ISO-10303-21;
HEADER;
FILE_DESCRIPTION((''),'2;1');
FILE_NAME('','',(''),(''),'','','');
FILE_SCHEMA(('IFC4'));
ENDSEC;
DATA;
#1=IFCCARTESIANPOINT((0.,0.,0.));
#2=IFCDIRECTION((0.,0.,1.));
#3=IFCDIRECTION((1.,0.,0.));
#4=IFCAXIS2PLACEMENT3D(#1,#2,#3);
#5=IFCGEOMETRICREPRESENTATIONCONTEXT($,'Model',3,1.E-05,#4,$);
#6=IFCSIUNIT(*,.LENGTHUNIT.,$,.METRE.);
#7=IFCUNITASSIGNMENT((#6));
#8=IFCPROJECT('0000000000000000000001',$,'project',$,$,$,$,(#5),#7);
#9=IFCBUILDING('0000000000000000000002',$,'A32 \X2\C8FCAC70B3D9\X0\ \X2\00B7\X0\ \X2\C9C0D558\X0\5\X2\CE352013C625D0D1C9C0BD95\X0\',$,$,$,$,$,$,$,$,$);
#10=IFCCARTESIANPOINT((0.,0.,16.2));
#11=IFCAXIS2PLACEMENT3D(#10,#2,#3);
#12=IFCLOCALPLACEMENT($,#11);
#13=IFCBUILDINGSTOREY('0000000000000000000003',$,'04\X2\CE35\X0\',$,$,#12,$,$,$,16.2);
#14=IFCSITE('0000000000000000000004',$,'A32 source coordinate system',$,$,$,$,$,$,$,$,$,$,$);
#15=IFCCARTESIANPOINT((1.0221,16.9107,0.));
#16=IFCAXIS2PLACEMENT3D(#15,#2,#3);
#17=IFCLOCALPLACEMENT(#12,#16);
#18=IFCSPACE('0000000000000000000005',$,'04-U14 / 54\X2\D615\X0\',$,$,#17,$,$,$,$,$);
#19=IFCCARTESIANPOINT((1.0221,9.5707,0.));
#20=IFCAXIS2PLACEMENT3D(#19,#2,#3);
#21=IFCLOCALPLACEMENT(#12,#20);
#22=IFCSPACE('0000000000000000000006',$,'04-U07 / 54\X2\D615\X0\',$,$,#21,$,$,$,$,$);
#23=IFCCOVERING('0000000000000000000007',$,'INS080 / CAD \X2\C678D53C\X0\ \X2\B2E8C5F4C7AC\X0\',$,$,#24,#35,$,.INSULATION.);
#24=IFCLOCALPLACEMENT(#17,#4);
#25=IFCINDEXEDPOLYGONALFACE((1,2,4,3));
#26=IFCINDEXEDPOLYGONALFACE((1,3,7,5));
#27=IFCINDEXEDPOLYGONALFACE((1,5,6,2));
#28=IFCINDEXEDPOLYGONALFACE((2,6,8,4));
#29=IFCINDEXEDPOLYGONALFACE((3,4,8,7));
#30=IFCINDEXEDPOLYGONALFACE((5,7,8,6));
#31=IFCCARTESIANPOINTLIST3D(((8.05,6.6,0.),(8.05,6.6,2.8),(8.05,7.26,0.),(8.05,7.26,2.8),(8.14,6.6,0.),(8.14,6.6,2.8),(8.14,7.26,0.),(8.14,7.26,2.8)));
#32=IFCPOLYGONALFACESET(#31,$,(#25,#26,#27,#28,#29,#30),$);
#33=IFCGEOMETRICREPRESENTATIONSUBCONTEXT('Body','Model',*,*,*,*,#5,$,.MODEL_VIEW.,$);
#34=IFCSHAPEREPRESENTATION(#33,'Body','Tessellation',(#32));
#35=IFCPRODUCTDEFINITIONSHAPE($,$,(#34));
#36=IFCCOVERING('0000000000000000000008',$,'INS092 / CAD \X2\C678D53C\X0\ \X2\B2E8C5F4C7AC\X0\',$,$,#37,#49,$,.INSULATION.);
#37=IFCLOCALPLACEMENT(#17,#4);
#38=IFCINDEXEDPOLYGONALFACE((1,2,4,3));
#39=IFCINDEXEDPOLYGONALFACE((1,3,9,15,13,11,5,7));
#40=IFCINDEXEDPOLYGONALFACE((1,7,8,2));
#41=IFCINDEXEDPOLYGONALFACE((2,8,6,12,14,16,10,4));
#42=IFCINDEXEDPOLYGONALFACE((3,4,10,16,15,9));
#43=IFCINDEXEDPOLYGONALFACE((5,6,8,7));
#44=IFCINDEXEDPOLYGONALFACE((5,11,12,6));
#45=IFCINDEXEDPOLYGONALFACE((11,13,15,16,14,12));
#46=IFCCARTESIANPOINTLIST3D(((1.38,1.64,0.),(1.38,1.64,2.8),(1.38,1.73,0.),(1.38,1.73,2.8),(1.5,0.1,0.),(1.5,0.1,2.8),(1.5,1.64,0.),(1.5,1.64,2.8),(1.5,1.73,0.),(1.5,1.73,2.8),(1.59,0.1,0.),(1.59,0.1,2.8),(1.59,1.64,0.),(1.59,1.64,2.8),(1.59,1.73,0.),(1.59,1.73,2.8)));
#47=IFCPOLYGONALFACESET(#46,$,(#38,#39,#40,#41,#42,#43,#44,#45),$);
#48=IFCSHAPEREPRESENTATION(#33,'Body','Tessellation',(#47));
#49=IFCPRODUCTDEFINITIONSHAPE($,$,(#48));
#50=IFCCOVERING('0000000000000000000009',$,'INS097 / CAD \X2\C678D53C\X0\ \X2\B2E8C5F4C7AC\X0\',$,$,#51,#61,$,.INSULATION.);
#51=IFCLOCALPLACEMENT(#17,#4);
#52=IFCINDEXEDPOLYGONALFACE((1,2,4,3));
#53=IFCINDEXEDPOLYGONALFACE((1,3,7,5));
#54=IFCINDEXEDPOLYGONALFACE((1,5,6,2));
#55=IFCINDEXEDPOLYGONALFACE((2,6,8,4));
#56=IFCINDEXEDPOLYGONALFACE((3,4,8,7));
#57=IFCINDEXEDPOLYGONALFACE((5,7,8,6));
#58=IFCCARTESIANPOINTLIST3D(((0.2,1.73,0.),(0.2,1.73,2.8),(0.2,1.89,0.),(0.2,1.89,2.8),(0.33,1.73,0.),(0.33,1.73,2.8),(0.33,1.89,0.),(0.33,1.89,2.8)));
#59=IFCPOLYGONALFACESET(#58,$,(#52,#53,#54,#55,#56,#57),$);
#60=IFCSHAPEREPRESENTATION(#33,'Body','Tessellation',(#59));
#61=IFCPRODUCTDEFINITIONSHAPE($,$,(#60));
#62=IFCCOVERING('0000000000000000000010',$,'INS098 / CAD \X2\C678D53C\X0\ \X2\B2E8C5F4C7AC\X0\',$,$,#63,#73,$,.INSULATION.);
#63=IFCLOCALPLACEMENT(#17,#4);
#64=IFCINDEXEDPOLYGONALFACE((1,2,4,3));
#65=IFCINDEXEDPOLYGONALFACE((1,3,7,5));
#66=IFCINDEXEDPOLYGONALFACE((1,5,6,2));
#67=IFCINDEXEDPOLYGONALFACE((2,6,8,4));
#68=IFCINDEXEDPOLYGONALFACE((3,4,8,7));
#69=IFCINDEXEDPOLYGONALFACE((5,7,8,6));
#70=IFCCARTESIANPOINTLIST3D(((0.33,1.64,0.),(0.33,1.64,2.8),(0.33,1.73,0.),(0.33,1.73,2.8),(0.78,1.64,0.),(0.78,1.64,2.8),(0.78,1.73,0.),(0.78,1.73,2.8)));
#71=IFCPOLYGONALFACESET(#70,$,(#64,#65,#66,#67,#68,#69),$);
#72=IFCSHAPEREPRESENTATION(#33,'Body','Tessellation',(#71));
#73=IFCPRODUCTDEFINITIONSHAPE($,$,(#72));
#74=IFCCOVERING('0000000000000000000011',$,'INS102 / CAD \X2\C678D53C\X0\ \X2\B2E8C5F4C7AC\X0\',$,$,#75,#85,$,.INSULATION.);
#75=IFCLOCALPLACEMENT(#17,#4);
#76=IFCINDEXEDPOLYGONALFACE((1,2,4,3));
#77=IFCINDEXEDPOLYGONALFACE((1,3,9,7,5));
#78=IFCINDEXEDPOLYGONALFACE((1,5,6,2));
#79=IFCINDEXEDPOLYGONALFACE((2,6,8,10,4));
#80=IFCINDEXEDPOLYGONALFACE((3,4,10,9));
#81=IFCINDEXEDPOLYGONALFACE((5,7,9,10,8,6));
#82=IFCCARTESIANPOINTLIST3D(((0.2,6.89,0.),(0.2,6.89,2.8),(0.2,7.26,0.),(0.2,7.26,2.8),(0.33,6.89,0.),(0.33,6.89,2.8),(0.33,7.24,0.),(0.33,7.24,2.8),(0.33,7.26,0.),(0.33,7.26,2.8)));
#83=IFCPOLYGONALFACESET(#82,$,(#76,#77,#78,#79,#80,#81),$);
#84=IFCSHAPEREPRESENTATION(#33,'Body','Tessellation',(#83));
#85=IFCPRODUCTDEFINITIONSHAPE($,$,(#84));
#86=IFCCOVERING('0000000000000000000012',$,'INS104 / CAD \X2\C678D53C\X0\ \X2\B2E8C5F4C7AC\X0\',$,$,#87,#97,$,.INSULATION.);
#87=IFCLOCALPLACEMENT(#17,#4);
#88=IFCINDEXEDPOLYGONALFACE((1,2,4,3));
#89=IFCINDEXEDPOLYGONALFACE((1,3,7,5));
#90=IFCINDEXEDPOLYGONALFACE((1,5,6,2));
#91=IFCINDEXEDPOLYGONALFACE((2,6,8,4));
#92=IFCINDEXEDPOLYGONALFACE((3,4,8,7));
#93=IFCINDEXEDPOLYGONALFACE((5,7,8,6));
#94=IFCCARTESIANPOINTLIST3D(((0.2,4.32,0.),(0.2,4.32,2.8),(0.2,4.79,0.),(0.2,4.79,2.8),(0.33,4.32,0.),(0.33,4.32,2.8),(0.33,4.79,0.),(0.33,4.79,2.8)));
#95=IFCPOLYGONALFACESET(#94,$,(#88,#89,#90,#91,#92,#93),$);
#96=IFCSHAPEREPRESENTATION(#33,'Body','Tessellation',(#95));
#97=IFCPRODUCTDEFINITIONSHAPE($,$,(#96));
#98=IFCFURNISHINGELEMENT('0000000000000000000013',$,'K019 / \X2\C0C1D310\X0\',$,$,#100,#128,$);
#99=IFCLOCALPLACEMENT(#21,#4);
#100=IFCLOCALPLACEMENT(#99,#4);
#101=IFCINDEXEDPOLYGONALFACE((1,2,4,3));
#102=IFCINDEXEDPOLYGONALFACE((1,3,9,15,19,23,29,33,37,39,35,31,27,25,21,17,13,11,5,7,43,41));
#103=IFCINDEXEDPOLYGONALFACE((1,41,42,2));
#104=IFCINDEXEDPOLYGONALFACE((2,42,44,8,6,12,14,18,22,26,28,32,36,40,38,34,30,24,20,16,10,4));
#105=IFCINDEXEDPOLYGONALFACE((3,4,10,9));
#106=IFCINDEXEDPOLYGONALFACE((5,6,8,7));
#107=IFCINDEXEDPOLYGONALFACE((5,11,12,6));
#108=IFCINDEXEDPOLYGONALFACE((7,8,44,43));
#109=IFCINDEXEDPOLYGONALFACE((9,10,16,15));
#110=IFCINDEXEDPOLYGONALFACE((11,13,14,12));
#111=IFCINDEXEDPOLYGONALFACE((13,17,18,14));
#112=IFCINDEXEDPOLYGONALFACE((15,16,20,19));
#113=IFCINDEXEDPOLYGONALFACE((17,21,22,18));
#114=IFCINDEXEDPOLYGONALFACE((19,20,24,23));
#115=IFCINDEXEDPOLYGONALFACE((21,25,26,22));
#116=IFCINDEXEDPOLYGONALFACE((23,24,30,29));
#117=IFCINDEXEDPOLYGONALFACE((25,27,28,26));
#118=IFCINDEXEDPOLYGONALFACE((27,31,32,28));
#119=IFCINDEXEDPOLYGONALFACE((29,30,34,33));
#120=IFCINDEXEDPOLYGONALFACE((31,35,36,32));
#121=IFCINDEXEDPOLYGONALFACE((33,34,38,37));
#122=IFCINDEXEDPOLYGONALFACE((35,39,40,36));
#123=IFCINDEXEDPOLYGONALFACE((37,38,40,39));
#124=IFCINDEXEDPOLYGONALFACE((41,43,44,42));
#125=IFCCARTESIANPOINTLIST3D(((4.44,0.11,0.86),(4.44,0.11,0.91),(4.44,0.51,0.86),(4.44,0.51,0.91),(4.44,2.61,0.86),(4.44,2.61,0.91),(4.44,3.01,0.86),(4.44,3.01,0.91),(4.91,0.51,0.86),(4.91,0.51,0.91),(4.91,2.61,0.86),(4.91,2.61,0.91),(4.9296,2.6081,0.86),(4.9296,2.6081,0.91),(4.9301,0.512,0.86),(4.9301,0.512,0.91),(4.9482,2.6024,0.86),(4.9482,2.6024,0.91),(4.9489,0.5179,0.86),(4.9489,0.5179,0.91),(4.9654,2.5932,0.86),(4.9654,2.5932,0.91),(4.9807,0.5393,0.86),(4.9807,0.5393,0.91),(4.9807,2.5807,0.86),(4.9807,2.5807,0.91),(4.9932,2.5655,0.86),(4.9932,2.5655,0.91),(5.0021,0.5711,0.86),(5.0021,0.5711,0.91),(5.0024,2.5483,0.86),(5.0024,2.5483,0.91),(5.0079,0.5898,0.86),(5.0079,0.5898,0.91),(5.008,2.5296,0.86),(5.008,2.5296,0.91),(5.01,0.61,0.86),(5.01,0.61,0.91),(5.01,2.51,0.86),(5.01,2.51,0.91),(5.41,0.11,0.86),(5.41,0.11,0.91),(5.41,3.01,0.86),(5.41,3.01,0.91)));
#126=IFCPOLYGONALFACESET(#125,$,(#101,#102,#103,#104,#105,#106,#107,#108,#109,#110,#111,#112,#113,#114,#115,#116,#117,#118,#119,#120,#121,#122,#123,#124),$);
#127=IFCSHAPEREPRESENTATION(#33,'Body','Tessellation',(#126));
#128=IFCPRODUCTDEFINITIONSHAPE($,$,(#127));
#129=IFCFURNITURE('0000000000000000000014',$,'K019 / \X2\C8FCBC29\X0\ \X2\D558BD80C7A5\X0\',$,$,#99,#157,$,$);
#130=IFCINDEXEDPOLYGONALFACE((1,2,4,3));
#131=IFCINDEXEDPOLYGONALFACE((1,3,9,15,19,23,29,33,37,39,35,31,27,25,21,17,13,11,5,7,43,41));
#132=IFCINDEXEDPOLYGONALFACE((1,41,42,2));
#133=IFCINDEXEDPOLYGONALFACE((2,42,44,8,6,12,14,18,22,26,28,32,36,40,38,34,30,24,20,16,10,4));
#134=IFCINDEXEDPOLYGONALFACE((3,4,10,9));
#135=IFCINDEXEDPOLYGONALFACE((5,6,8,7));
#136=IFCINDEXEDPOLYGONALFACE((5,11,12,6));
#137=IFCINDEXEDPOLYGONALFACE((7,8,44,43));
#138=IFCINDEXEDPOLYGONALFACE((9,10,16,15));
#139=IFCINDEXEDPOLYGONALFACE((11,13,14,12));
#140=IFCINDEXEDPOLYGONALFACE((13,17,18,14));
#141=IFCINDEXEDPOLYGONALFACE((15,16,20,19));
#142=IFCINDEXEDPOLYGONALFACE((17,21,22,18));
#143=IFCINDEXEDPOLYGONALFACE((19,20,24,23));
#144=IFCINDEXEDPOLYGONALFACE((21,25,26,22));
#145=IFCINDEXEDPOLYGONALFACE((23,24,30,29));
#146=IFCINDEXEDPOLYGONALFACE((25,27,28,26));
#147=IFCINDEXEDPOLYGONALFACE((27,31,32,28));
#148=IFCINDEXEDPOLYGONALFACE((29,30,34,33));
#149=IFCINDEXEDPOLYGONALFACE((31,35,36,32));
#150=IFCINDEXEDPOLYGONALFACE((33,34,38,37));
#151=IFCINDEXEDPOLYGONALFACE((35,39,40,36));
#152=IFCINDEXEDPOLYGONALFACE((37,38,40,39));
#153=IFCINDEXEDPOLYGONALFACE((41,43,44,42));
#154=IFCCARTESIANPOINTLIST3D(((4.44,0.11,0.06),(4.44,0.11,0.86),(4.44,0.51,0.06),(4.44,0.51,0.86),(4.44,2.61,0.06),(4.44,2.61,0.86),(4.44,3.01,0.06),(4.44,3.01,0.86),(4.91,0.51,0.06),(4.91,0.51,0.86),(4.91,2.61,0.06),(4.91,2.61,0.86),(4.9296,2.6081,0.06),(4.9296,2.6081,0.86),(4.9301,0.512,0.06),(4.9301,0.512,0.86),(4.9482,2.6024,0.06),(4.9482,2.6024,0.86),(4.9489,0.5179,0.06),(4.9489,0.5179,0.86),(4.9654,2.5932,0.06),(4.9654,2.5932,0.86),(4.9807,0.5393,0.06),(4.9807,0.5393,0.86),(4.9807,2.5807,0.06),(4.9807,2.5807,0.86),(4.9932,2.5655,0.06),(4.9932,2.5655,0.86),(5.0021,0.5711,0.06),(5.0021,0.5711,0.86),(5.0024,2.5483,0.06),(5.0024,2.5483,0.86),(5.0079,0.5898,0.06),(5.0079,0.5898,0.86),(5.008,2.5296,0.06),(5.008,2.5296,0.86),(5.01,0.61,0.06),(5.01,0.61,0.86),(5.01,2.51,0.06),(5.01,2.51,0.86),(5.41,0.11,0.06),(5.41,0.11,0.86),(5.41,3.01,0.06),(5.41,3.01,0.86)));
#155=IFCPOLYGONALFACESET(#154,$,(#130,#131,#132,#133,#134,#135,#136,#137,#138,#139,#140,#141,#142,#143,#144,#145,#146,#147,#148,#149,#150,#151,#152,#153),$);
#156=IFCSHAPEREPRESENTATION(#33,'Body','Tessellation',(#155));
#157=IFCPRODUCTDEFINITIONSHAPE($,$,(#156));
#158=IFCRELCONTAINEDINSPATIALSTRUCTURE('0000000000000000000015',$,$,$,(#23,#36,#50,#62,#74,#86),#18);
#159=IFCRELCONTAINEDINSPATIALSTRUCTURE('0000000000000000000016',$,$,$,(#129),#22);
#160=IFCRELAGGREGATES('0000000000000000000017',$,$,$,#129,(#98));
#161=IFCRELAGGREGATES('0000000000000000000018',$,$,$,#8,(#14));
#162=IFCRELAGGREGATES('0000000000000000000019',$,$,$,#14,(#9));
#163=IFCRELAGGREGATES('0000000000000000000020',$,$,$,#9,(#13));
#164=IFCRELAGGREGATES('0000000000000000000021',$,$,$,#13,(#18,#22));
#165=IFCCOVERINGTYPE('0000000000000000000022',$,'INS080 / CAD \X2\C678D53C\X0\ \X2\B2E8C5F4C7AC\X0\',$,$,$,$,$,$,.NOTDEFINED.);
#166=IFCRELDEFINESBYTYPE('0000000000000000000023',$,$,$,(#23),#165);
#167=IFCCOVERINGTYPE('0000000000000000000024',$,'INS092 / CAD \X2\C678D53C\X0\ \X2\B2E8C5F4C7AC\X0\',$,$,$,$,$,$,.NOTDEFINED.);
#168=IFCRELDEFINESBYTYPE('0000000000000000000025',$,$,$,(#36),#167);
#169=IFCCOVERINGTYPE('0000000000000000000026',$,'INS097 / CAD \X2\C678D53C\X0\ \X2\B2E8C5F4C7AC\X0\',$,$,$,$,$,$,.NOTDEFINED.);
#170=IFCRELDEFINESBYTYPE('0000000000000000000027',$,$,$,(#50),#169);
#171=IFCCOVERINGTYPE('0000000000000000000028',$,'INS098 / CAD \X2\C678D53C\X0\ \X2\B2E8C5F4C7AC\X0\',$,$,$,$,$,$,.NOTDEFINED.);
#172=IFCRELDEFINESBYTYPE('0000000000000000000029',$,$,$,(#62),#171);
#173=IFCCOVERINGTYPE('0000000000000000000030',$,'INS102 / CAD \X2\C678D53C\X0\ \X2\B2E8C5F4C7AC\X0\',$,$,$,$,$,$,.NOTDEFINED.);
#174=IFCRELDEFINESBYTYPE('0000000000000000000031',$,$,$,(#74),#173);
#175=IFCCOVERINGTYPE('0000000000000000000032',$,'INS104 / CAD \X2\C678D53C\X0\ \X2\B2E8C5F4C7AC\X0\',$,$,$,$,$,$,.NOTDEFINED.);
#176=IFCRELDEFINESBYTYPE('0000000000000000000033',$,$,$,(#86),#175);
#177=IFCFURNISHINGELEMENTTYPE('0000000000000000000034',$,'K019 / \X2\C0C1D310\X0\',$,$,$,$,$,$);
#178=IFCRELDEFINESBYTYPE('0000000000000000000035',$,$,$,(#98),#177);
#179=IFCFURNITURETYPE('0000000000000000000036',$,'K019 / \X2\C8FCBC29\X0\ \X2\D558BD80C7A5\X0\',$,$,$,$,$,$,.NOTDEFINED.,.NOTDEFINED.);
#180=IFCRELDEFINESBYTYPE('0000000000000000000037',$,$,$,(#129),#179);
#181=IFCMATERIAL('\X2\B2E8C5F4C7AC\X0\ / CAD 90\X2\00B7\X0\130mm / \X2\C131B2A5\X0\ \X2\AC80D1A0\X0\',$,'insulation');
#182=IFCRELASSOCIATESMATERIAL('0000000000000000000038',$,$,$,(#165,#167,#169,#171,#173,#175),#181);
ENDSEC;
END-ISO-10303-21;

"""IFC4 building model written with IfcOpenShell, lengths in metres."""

from ifc_helpers import new_model, si_unit, frame, origin, origin_with_axes, place, context, subcontext, project, spatial, polyline, outline, extrude, source, transform, mapped, material, type_object, type_shapes, element, aggregate, save


model = new_model("IFC4")

# Units and contexts
model_context = context("Model", 3, precision=1e-05, world=origin_with_axes())
body_context = subcontext(model_context, "Body", "Model", "MODEL_VIEW")
ifc_project = project(units=[si_unit("LENGTHUNIT", "METRE")], contexts=[model_context])

# Site, building, storey, space
storey_placement = place(None, frame((0.0, 0.0, 16.2), z_axis=(0.0, 0.0, 1.0), x_axis=(1.0, 0.0, 0.0)))
space_1_placement = place(storey_placement, frame((1.0221, 16.9107, 0.0), z_axis=(0.0, 0.0, 1.0), x_axis=(1.0, 0.0, 0.0)))
site = spatial("IfcSite", under=ifc_project, Name="A32 source coordinate system")
building = spatial("IfcBuilding", under=site, Name="A32 주거동 · 지하5층–옥탑지붕")
storey = spatial("IfcBuildingStorey", under=building, at=storey_placement, Name="04층", Elevation=16.2)
space_1 = spatial("IfcSpace", under=storey, at=space_1_placement, Name="04-U14 / 54형")

# Coverings
ifc_material = material(Name="단열재 / CAD 90·130mm / 성능 검토", Category="insulation")
covering_type_1 = type_object("IfcCoveringType", Name="INS080 / CAD 외피 단열재", PredefinedType="NOTDEFINED", material=ifc_material)
shared_shape_1 = source(origin(), body_context, "Body", "SweptSolid", [
    extrude(outline(polyline([(8.14, 7.26), (8.14, 6.6), (8.05, 6.6), (8.05, 7.26), (8.14, 7.26)])), origin(), (0.0, 0.0, 1.0), 2.8),
])
type_shapes(covering_type_1, [shared_shape_1])
covering_1_placement = place(space_1_placement, origin_with_axes())
element("IfcCovering", 1, at=covering_1_placement, inside=space_1, type_object=covering_type_1, Name="INS080 / CAD 외피 단열재", PredefinedType="INSULATION", context=body_context, shape_type="MappedRepresentation", body=[
    mapped(shared_shape_1, transform((0.0, 0.0, 0.0), scale=1.0)),
])
covering_type_2 = type_object("IfcCoveringType", Name="INS092 / CAD 외피 단열재", PredefinedType="NOTDEFINED", material=ifc_material)
shared_shape_2 = source(origin(), body_context, "Body", "SweptSolid", [
    extrude(outline(polyline([(1.59, 1.73), (1.59, 1.64), (1.59, 0.1), (1.5, 0.1), (1.5, 1.64), (1.38, 1.64), (1.38, 1.73), (1.5, 1.73), (1.59, 1.73)])), origin(), (0.0, 0.0, 1.0), 2.8),
])
type_shapes(covering_type_2, [shared_shape_2])
covering_2_placement = place(space_1_placement, origin_with_axes())
element("IfcCovering", 2, at=covering_2_placement, inside=space_1, type_object=covering_type_2, Name="INS092 / CAD 외피 단열재", PredefinedType="INSULATION", context=body_context, shape_type="MappedRepresentation", body=[
    mapped(shared_shape_2, transform((0.0, 0.0, 0.0), scale=1.0)),
])
covering_type_3 = type_object("IfcCoveringType", Name="INS097 / CAD 외피 단열재", PredefinedType="NOTDEFINED", material=ifc_material)
shared_shape_3 = source(origin(), body_context, "Body", "SweptSolid", [
    extrude(outline(polyline([(0.33, 1.89), (0.33, 1.73), (0.2, 1.73), (0.2, 1.89), (0.33, 1.89)])), origin(), (0.0, 0.0, 1.0), 2.8),
])
type_shapes(covering_type_3, [shared_shape_3])
covering_3_placement = place(space_1_placement, origin_with_axes())
element("IfcCovering", 3, at=covering_3_placement, inside=space_1, type_object=covering_type_3, Name="INS097 / CAD 외피 단열재", PredefinedType="INSULATION", context=body_context, shape_type="MappedRepresentation", body=[
    mapped(shared_shape_3, transform((0.0, 0.0, 0.0), scale=1.0)),
])
covering_type_4 = type_object("IfcCoveringType", Name="INS098 / CAD 외피 단열재", PredefinedType="NOTDEFINED", material=ifc_material)
shared_shape_4 = source(origin(), body_context, "Body", "SweptSolid", [
    extrude(outline(polyline([(0.78, 1.73), (0.78, 1.64), (0.33, 1.64), (0.33, 1.73), (0.78, 1.73)])), origin(), (0.0, 0.0, 1.0), 2.8),
])
type_shapes(covering_type_4, [shared_shape_4])
covering_4_placement = place(space_1_placement, origin_with_axes())
element("IfcCovering", 4, at=covering_4_placement, inside=space_1, type_object=covering_type_4, Name="INS098 / CAD 외피 단열재", PredefinedType="INSULATION", context=body_context, shape_type="MappedRepresentation", body=[
    mapped(shared_shape_4, transform((0.0, 0.0, 0.0), scale=1.0)),
])
covering_type_5 = type_object("IfcCoveringType", Name="INS102 / CAD 외피 단열재", PredefinedType="NOTDEFINED", material=ifc_material)
shared_shape_5 = source(origin(), body_context, "Body", "SweptSolid", [
    extrude(outline(polyline([(0.33, 7.26), (0.33, 7.24), (0.33, 6.89), (0.2, 6.89), (0.2, 7.26), (0.33, 7.26)])), origin(), (0.0, 0.0, 1.0), 2.8),
])
type_shapes(covering_type_5, [shared_shape_5])
covering_5_placement = place(space_1_placement, origin_with_axes())
element("IfcCovering", 5, at=covering_5_placement, inside=space_1, type_object=covering_type_5, Name="INS102 / CAD 외피 단열재", PredefinedType="INSULATION", context=body_context, shape_type="MappedRepresentation", body=[
    mapped(shared_shape_5, transform((0.0, 0.0, 0.0), scale=1.0)),
])
covering_type_6 = type_object("IfcCoveringType", Name="INS104 / CAD 외피 단열재", PredefinedType="NOTDEFINED", material=ifc_material)
shared_shape_6 = source(origin(), body_context, "Body", "SweptSolid", [
    extrude(outline(polyline([(0.33, 4.32), (0.2, 4.32), (0.2, 4.79), (0.33, 4.79), (0.33, 4.32)])), origin(), (0.0, 0.0, 1.0), 2.8),
])
type_shapes(covering_type_6, [shared_shape_6])
covering_6_placement = place(space_1_placement, origin_with_axes())
element("IfcCovering", 6, at=covering_6_placement, inside=space_1, type_object=covering_type_6, Name="INS104 / CAD 외피 단열재", PredefinedType="INSULATION", context=body_context, shape_type="MappedRepresentation", body=[
    mapped(shared_shape_6, transform((0.0, 0.0, 0.0), scale=1.0)),
])

# Shared definitions
space_2_placement = place(storey_placement, frame((1.0221, 9.5707, 0.0), z_axis=(0.0, 0.0, 1.0), x_axis=(1.0, 0.0, 0.0)))

# Furnishing element
furnishing_element_type_1 = type_object("IfcFurnishingElementType", Name="K019 / 상판")
shared_shape_7 = source(origin(), body_context, "Body", "SweptSolid", [
    extrude(outline(polyline([(4.91, 0.51), (4.9301, 0.512), (4.9489, 0.5179), (4.9807, 0.5393), (5.0021, 0.5711), (5.0079, 0.5898), (5.01, 0.61), (5.01, 2.51), (5.008, 2.5296), (5.0024, 2.5483), (4.9932, 2.5655), (4.9807, 2.5807), (4.9654, 2.5932), (4.9482, 2.6024), (4.9296, 2.6081), (4.91, 2.61), (4.44, 2.61), (4.44, 3.01), (5.41, 3.01), (5.41, 0.11), (4.44, 0.11), (4.44, 0.51), (4.91, 0.51)])), frame((0.0, 0.0, 0.86)), (0.0, 0.0, 1.0), 0.05),
])
type_shapes(furnishing_element_type_1, [shared_shape_7])
furniture_1_placement = place(space_2_placement, origin_with_axes())
furnishing_1_placement = place(furniture_1_placement, origin_with_axes())
furnishing_1 = element("IfcFurnishingElement", 7, at=furnishing_1_placement, type_object=furnishing_element_type_1, Name="K019 / 상판", context=body_context, shape_type="MappedRepresentation", body=[
    mapped(shared_shape_7, transform((0.0, 0.0, 0.0), scale=1.0)),
])

# Shared definitions
space_2 = spatial("IfcSpace", under=storey, at=space_2_placement, Name="04-U07 / 54형")

# Furniture
furniture_type_1 = type_object("IfcFurnitureType", Name="K019 / 주방 하부장", AssemblyPlace="NOTDEFINED", PredefinedType="NOTDEFINED")
shared_shape_8 = source(origin(), body_context, "Body", "SweptSolid", [
    extrude(outline(polyline([(4.44, 0.51), (4.91, 0.51), (4.9301, 0.512), (4.9489, 0.5179), (4.9807, 0.5393), (5.0021, 0.5711), (5.0079, 0.5898), (5.01, 0.61), (5.01, 2.51), (5.008, 2.5296), (5.0024, 2.5483), (4.9932, 2.5655), (4.9807, 2.5807), (4.9654, 2.5932), (4.9482, 2.6024), (4.9296, 2.6081), (4.91, 2.61), (4.44, 2.61), (4.44, 3.01), (5.41, 3.01), (5.41, 0.11), (4.44, 0.11), (4.44, 0.51)])), frame((0.0, 0.0, 0.06)), (0.0, 0.0, 1.0), 0.8),
])
type_shapes(furniture_type_1, [shared_shape_8])
furniture_1 = element("IfcFurniture", 8, at=furniture_1_placement, inside=space_2, type_object=furniture_type_1, Name="K019 / 주방 하부장", context=body_context, shape_type="MappedRepresentation", body=[
    mapped(shared_shape_8, transform((0.0, 0.0, 0.0), scale=1.0)),
])
aggregate(furniture_1, [furnishing_1])

save(model, "model.ifc")
